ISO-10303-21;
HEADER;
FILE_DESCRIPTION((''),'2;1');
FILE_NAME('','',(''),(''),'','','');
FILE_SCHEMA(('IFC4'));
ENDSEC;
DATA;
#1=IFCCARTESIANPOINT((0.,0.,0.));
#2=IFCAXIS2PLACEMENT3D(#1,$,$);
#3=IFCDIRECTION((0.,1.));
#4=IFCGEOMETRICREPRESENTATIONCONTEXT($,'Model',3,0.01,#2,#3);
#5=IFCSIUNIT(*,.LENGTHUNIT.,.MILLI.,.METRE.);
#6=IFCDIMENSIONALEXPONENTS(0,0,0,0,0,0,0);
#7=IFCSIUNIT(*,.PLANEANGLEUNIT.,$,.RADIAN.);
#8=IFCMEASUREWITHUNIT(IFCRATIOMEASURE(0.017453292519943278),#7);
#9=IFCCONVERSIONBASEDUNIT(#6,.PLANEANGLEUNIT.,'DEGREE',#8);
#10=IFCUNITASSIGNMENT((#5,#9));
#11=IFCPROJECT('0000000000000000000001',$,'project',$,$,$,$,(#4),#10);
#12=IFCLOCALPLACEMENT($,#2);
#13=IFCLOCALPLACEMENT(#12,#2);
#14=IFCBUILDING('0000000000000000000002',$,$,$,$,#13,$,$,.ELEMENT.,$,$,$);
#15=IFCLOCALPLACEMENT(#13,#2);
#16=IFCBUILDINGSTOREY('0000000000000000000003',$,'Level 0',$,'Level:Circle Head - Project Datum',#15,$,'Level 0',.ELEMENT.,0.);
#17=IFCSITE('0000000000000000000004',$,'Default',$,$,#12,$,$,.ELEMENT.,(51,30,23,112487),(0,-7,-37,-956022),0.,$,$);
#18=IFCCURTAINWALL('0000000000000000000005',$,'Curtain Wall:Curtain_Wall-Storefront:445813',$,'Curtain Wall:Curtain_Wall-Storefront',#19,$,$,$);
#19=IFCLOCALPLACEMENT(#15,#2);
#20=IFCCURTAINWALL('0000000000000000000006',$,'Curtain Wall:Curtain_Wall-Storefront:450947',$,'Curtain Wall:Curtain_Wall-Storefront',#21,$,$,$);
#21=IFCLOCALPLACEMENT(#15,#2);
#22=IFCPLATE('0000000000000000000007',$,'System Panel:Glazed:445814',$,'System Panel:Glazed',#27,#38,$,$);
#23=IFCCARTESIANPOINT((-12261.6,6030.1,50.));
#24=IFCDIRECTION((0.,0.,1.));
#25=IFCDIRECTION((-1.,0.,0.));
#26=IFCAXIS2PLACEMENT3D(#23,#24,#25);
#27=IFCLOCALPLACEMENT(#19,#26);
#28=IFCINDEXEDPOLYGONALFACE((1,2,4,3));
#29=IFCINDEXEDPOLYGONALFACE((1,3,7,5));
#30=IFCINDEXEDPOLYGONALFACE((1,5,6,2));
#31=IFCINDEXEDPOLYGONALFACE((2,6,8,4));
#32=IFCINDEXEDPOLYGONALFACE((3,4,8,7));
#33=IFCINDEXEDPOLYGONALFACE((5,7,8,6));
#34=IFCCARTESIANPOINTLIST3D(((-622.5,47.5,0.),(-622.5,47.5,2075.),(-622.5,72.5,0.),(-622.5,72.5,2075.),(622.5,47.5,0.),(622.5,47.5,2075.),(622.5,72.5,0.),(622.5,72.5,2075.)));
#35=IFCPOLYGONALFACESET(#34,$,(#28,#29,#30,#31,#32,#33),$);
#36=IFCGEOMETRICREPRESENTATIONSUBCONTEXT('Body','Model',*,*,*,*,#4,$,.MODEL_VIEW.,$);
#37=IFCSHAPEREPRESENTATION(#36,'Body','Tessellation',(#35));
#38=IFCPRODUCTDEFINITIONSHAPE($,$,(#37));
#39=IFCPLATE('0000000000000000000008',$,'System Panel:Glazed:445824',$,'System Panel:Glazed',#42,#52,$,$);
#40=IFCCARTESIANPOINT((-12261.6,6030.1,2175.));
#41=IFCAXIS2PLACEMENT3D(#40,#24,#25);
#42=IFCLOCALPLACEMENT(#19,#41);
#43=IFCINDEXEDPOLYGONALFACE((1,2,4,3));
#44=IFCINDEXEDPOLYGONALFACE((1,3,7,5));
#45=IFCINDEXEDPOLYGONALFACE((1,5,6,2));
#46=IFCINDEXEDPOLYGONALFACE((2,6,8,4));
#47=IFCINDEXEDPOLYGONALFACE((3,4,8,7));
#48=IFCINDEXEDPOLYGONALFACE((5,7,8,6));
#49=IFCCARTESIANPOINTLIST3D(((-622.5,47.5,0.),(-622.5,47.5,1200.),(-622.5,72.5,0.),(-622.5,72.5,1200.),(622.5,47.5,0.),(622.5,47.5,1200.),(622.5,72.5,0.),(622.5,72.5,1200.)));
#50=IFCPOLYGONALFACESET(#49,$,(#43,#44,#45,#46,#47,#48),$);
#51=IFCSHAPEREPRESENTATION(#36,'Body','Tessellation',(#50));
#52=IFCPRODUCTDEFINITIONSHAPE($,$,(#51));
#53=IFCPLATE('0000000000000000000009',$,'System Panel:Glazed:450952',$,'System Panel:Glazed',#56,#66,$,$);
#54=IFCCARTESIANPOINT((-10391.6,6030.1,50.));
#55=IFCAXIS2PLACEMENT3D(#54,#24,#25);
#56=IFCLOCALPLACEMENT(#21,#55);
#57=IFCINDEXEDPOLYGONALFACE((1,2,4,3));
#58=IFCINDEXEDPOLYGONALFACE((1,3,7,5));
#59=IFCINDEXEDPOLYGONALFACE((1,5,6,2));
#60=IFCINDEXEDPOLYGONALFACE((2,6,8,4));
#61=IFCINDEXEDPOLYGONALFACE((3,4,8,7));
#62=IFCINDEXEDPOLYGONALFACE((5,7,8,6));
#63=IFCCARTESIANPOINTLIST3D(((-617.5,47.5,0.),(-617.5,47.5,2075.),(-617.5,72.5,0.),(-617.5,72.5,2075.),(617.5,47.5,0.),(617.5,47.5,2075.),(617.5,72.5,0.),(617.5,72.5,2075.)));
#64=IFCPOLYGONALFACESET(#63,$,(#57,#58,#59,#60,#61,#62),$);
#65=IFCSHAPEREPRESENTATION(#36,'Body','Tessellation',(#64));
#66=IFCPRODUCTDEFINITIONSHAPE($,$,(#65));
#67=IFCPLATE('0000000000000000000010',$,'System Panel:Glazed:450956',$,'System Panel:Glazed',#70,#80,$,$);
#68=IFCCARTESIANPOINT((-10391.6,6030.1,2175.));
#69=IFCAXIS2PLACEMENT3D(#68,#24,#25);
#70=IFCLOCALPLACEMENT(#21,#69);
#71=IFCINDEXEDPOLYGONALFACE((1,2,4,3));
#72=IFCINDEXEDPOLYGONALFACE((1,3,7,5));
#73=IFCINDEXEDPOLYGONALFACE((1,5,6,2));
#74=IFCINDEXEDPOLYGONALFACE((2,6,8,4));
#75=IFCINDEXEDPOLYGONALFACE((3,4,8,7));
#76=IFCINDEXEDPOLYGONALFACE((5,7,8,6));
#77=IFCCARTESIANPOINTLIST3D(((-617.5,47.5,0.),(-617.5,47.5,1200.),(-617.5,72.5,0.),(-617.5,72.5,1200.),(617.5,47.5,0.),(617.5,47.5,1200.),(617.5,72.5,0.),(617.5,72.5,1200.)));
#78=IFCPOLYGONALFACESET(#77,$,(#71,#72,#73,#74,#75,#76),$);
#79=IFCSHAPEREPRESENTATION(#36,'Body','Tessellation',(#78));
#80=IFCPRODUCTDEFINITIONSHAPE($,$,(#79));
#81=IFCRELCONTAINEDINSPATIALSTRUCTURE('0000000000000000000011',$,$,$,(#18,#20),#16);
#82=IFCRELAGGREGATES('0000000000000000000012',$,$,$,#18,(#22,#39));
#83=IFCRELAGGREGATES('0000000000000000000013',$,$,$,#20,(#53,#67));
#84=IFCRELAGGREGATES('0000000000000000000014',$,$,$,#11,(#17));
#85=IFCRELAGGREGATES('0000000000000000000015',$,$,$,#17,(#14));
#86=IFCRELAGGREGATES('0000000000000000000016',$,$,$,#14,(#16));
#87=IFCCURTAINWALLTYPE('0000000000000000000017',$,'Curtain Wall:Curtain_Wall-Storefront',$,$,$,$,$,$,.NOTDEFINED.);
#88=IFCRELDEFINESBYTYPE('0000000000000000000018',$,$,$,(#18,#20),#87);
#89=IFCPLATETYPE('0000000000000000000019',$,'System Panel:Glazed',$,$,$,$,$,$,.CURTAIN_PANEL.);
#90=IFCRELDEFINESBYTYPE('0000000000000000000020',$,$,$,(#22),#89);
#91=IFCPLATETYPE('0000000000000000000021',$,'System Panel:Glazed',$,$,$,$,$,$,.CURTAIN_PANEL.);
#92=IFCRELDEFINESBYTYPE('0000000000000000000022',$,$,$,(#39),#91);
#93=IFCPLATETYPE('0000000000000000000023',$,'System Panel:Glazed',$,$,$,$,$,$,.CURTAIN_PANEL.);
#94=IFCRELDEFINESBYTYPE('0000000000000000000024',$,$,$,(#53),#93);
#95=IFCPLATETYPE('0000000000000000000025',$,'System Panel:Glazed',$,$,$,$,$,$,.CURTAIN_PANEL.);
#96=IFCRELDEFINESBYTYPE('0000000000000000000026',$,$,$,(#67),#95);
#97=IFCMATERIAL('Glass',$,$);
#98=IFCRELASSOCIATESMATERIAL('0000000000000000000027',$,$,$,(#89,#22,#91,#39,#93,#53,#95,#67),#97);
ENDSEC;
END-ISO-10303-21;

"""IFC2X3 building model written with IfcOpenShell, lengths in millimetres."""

from ifc_helpers import new_model, entity, si_unit, converted_unit, direction, frame, origin, origin_2d_with_axis, place, context, subcontext, project, spatial, rectangle, extrude, source, transform, mapped, material, type_object, type_shapes, element, aggregate, save


model = new_model("IFC2X3")

# Units and contexts
model_context = context("Model", 3, precision=0.01, world=origin(), true_north=direction((0.0, 1.0)))
body_context = subcontext(model_context, "Body", "Model", "MODEL_VIEW")
ifc_project = project(units=[si_unit("LENGTHUNIT", "METRE", prefix="MILLI"), converted_unit("PLANEANGLEUNIT", "DEGREE", entity("IfcRatioMeasure", 0.017453292519943278), si_unit("PLANEANGLEUNIT", "RADIAN"), dimensions=[0, 0, 0, 0, 0, 0, 0])], contexts=[model_context])

# Site, building, storey
site_placement = place(None, origin())
site = spatial("IfcSite", under=ifc_project, at=site_placement, Name="Default", CompositionType="ELEMENT", RefLatitude=(51, 30, 23, 112487), RefLongitude=(0, -7, -37, -956022), RefElevation=0.0)
building_placement = place(site_placement, origin())
building = spatial("IfcBuilding", under=site, at=building_placement, CompositionType="ELEMENT")
storey_placement = place(building_placement, origin())
storey = spatial("IfcBuildingStorey", under=building, at=storey_placement, Name="Level 0", ObjectType="Level:Circle Head - Project Datum", LongName="Level 0", CompositionType="ELEMENT", Elevation=0.0)

# Curtain walls
curtain_wall_type = type_object("IfcCurtainWallType", Name="Curtain Wall:Curtain_Wall-Storefront", PredefinedType="NOTDEFINED")
curtain_wall_1_placement = place(storey_placement, origin())
curtain_wall_1 = element("IfcCurtainWall", 1, at=curtain_wall_1_placement, inside=storey, type_object=curtain_wall_type, Name="Curtain Wall:Curtain_Wall-Storefront:445813", ObjectType="Curtain Wall:Curtain_Wall-Storefront")
curtain_wall_2_placement = place(storey_placement, origin())
curtain_wall_2 = element("IfcCurtainWall", 2, at=curtain_wall_2_placement, inside=storey, type_object=curtain_wall_type, Name="Curtain Wall:Curtain_Wall-Storefront:450947", ObjectType="Curtain Wall:Curtain_Wall-Storefront")

# Plates
ifc_material_1 = material(Name="Glass")
plate_type_1 = type_object("IfcPlateType", Name="System Panel:Glazed", PredefinedType="CURTAIN_PANEL", material=ifc_material_1)
shared_shape_1 = source(origin(), body_context, "Body", "SweptSolid", [
    extrude(rectangle(XDim=25.0, YDim=1245.0, at=origin_2d_with_axis()), frame((0.0, 60.0, 0.0), z_axis=(0.0, 0.0, 1.0), x_axis=(0.0, 1.0, 0.0)), (0.0, 0.0, 1.0), 2075.0),
])
type_shapes(plate_type_1, [shared_shape_1])
plate_1_placement = place(curtain_wall_1_placement, frame((-12261.6, 6030.1, 50.0), z_axis=(0.0, 0.0, 1.0), x_axis=(-1.0, 0.0, 0.0)))
plate_1 = element("IfcPlate", 3, at=plate_1_placement, type_object=plate_type_1, material=ifc_material_1, Name="System Panel:Glazed:445814", ObjectType="System Panel:Glazed", context=body_context, shape_type="MappedRepresentation", body=[
    mapped(shared_shape_1, transform((0.0, 0.0, 0.0), scale=1.0)),
])
plate_type_2 = type_object("IfcPlateType", Name="System Panel:Glazed", PredefinedType="CURTAIN_PANEL", material=ifc_material_1)
shared_shape_2 = source(origin(), body_context, "Body", "SweptSolid", [
    extrude(rectangle(XDim=25.0, YDim=1245.0, at=origin_2d_with_axis()), frame((0.0, 60.0, 0.0), z_axis=(0.0, 0.0, 1.0), x_axis=(0.0, 1.0, 0.0)), (0.0, 0.0, 1.0), 1200.0),
])
type_shapes(plate_type_2, [shared_shape_2])
plate_2_placement = place(curtain_wall_1_placement, frame((-12261.6, 6030.1, 2175.0), z_axis=(0.0, 0.0, 1.0), x_axis=(-1.0, 0.0, 0.0)))
plate_2 = element("IfcPlate", 4, at=plate_2_placement, type_object=plate_type_2, material=ifc_material_1, Name="System Panel:Glazed:445824", ObjectType="System Panel:Glazed", context=body_context, shape_type="MappedRepresentation", body=[
    mapped(shared_shape_2, transform((0.0, 0.0, 0.0), scale=1.0)),
])
aggregate(curtain_wall_1, [plate_1, plate_2])
plate_type_3 = type_object("IfcPlateType", Name="System Panel:Glazed", PredefinedType="CURTAIN_PANEL", material=ifc_material_1)
shared_shape_3 = source(origin(), body_context, "Body", "SweptSolid", [
    extrude(rectangle(XDim=25.0, YDim=1235.0, at=origin_2d_with_axis()), frame((0.0, 60.0, 0.0), z_axis=(0.0, 0.0, 1.0), x_axis=(0.0, 1.0, 0.0)), (0.0, 0.0, 1.0), 2075.0),
])
type_shapes(plate_type_3, [shared_shape_3])
plate_3_placement = place(curtain_wall_2_placement, frame((-10391.6, 6030.1, 50.0), z_axis=(0.0, 0.0, 1.0), x_axis=(-1.0, 0.0, 0.0)))
plate_3 = element("IfcPlate", 5, at=plate_3_placement, type_object=plate_type_3, material=ifc_material_1, Name="System Panel:Glazed:450952", ObjectType="System Panel:Glazed", context=body_context, shape_type="MappedRepresentation", body=[
    mapped(shared_shape_3, transform((0.0, 0.0, 0.0), scale=1.0)),
])
plate_type_4 = type_object("IfcPlateType", Name="System Panel:Glazed", PredefinedType="CURTAIN_PANEL", material=ifc_material_1)
shared_shape_4 = source(origin(), body_context, "Body", "SweptSolid", [
    extrude(rectangle(XDim=25.0, YDim=1235.0, at=origin_2d_with_axis()), frame((0.0, 60.0, 0.0), z_axis=(0.0, 0.0, 1.0), x_axis=(0.0, 1.0, 0.0)), (0.0, 0.0, 1.0), 1200.0),
])
type_shapes(plate_type_4, [shared_shape_4])
plate_4_placement = place(curtain_wall_2_placement, frame((-10391.6, 6030.1, 2175.0), z_axis=(0.0, 0.0, 1.0), x_axis=(-1.0, 0.0, 0.0)))
plate_4 = element("IfcPlate", 6, at=plate_4_placement, type_object=plate_type_4, material=ifc_material_1, Name="System Panel:Glazed:450956", ObjectType="System Panel:Glazed", context=body_context, shape_type="MappedRepresentation", body=[
    mapped(shared_shape_4, transform((0.0, 0.0, 0.0), scale=1.0)),
])
aggregate(curtain_wall_2, [plate_3, plate_4])

save(model, "model.ifc")
